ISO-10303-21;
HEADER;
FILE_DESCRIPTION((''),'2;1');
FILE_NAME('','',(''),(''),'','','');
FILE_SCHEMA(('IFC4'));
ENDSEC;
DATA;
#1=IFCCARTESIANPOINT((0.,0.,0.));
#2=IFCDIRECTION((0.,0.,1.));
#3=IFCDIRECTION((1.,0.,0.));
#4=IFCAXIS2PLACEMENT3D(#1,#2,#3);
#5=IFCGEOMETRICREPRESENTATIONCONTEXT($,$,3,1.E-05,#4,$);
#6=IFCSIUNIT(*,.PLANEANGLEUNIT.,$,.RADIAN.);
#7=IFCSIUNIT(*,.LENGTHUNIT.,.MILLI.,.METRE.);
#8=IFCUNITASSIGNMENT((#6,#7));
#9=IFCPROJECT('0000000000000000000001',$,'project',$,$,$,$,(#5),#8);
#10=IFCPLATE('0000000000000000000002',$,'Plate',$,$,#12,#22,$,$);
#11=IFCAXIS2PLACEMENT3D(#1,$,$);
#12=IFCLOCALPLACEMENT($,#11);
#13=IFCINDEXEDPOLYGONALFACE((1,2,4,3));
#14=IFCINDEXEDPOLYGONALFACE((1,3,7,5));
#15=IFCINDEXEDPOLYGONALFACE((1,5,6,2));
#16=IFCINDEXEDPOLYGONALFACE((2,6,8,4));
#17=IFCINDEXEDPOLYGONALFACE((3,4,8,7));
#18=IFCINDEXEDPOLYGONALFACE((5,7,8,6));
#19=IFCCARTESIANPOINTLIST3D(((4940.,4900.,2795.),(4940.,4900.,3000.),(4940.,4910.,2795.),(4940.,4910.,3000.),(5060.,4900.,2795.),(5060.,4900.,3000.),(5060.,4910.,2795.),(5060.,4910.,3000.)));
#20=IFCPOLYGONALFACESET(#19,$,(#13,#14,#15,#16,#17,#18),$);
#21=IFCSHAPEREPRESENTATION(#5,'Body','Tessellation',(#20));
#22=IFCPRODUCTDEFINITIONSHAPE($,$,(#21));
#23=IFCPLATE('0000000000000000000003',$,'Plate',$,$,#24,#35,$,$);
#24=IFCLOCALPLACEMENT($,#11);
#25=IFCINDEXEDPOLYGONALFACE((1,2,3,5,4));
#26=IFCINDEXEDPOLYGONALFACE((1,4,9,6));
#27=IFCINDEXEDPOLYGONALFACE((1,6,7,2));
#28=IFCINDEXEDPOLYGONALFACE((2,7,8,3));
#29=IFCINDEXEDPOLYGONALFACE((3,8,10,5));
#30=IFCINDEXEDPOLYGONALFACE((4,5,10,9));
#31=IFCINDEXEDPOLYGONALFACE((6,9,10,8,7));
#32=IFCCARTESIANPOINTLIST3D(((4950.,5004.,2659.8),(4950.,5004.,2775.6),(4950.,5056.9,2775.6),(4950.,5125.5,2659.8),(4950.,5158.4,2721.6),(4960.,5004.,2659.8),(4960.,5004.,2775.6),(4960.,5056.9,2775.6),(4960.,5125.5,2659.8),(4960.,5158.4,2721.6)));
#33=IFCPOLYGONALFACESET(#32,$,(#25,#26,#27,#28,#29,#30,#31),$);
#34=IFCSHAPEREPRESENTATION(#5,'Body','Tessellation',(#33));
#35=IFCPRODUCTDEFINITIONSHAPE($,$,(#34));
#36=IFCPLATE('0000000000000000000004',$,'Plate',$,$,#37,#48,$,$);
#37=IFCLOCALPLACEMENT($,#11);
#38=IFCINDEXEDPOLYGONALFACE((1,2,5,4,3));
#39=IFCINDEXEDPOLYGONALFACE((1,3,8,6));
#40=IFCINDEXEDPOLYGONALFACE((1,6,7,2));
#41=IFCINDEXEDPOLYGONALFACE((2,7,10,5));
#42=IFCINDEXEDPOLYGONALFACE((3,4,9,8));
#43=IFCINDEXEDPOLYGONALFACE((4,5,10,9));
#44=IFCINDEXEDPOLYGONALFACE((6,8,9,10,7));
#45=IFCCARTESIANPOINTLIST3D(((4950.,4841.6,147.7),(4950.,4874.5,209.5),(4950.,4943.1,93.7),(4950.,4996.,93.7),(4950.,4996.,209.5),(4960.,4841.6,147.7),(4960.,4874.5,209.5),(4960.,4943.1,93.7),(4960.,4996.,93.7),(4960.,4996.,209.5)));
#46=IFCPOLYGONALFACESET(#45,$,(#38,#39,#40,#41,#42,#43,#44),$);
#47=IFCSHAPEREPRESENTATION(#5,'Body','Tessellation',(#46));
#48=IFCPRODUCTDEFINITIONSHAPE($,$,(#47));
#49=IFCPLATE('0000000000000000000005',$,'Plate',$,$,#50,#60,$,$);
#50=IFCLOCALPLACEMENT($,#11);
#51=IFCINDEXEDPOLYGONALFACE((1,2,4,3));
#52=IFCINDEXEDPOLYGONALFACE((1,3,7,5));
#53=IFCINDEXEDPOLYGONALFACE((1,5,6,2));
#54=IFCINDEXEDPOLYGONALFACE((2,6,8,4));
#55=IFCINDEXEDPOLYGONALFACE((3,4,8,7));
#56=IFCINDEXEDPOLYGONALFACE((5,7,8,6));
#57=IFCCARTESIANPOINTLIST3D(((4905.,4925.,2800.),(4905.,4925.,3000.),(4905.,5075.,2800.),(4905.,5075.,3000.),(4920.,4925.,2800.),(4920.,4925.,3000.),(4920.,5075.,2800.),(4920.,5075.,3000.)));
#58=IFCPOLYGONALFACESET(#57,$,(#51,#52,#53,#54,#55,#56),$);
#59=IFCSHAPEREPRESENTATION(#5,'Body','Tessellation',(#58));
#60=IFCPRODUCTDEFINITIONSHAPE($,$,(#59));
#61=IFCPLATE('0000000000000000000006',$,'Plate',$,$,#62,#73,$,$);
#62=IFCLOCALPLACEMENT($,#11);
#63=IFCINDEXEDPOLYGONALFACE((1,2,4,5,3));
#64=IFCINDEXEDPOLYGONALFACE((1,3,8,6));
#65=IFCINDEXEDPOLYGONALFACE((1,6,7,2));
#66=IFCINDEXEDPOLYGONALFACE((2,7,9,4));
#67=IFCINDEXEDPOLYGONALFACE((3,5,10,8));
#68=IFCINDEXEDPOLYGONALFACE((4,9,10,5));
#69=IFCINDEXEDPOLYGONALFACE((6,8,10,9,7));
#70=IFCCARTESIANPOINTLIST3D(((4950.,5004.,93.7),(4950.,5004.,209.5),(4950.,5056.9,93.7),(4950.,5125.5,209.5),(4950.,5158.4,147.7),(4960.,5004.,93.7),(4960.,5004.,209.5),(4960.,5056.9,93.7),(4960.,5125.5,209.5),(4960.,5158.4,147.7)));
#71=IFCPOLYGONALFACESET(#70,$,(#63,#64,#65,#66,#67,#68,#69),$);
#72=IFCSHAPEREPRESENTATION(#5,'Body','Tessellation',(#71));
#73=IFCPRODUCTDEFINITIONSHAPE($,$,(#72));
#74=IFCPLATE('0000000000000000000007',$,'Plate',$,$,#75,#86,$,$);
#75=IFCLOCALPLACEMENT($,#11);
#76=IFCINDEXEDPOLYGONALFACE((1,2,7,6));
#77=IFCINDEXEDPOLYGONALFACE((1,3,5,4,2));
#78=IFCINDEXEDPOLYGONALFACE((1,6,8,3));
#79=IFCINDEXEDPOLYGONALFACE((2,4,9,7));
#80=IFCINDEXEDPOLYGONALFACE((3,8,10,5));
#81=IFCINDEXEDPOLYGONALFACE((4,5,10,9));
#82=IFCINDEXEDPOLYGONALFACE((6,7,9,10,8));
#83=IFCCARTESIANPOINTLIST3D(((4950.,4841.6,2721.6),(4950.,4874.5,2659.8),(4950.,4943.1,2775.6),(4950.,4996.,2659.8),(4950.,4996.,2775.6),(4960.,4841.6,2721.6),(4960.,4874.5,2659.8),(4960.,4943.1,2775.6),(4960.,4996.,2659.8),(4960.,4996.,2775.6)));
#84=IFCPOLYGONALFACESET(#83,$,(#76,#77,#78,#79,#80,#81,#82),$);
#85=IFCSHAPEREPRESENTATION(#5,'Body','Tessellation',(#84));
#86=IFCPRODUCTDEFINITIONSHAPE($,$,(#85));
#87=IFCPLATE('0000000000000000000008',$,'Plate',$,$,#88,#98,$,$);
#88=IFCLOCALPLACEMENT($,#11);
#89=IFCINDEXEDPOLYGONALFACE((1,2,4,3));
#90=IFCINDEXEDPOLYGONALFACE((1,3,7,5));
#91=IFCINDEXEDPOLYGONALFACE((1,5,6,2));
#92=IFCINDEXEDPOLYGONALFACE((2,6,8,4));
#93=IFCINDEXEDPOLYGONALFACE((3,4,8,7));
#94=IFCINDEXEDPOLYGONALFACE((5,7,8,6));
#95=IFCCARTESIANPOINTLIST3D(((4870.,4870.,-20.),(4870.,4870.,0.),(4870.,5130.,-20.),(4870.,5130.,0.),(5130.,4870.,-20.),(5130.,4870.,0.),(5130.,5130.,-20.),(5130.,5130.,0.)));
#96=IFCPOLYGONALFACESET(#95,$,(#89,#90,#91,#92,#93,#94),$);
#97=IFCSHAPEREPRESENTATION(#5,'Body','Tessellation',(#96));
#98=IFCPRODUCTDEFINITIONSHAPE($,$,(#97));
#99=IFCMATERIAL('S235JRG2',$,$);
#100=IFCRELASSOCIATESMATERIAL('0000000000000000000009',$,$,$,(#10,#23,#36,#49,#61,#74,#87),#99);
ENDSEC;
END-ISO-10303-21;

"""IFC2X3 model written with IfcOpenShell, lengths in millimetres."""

from ifc_helpers import new_model, si_unit, frame, origin_with_axes, place, context, project, polyline, outline, extrude, material, element, save


model = new_model("IFC2X3")

# Units and contexts
context_of_model = context(None, 3, precision=1e-05, world=origin_with_axes())
ifc_project = project(units=[si_unit("PLANEANGLEUNIT", "RADIAN"), si_unit("LENGTHUNIT", "METRE", prefix="MILLI")], contexts=[context_of_model])

# Shared definitions
ifc_material = material(Name="S235JRG2")

# Plates
placement_1 = place(None, origin_with_axes())
plate_1_placement = place(placement_1, frame((5060.0, 4900.0, 2795.0), z_axis=(0.0, 0.0, 1.0), x_axis=(0.0, 1.0, 0.0)))
element("IfcPlate", 1, at=plate_1_placement, material=ifc_material, Name="Plate", context=context_of_model, shape_type="SweptSolid", body=[
    extrude(outline(polyline([(0.0, 0.0), (120.0, 0.0), (120.0, 205.0), (0.0, 205.0), (0.0, 0.0)])), frame((0.0, 0.0, 0.0), z_axis=(1.0, 0.0, 0.0), x_axis=(0.0, 1.0, 0.0)), (0.0, 0.0, 1.0), 10.0),
])
placement_2 = place(None, origin_with_axes())
plate_2_placement = place(placement_2, frame((4950.0, 5056.9, 2775.6), z_axis=(0.0, 0.0, -1.0), x_axis=(1.0, 0.0, 0.0)))
element("IfcPlate", 2, at=plate_2_placement, material=ifc_material, Name="Plate", context=context_of_model, shape_type="SweptSolid", body=[
    extrude(outline(polyline([(0.0, 0.0), (52.9, 0.0), (52.9, 115.8), (-68.6, 115.8), (-101.5, 54.1), (0.0, 0.0)])), frame((0.0, 0.0, 0.0), z_axis=(1.0, 0.0, 0.0), x_axis=(0.0, 1.0, 0.0)), (0.0, 0.0, 1.0), 10.0),
])
placement_3 = place(None, origin_with_axes())
plate_3_placement = place(placement_3, frame((4950.0, 4943.1, 93.7), z_axis=(0.0, 0.0, 1.0), x_axis=(1.0, 0.0, 0.0)))
element("IfcPlate", 3, at=plate_3_placement, material=ifc_material, Name="Plate", context=context_of_model, shape_type="SweptSolid", body=[
    extrude(outline(polyline([(0.0, 0.0), (52.9, 0.0), (52.9, 115.8), (-68.6, 115.8), (-101.5, 54.1), (0.0, 0.0)])), frame((0.0, 0.0, 0.0), z_axis=(1.0, 0.0, 0.0), x_axis=(0.0, 1.0, 0.0)), (0.0, 0.0, 1.0), 10.0),
])
placement_4 = place(None, origin_with_axes())
plate_4_placement = place(placement_4, frame((4905.0, 5075.0, 2800.0), z_axis=(0.0, -1.0, 0.0), x_axis=(1.0, 0.0, 0.0)))
element("IfcPlate", 4, at=plate_4_placement, material=ifc_material, Name="Plate", context=context_of_model, shape_type="SweptSolid", body=[
    extrude(outline(polyline([(0.0, 0.0), (200.0, 0.0), (200.0, 150.0), (0.0, 150.0), (0.0, 0.0)])), frame((0.0, 0.0, 0.0), z_axis=(1.0, 0.0, 0.0), x_axis=(0.0, 1.0, 0.0)), (0.0, 0.0, 1.0), 15.0),
])
placement_5 = place(None, origin_with_axes())
plate_5_placement = place(placement_5, frame((4960.0, 5056.9, 93.7), z_axis=(0.0, 0.0, 1.0), x_axis=(-1.0, 0.0, 0.0)))
element("IfcPlate", 5, at=plate_5_placement, material=ifc_material, Name="Plate", context=context_of_model, shape_type="SweptSolid", body=[
    extrude(outline(polyline([(0.0, 0.0), (52.9, 0.0), (52.9, 115.8), (-68.6, 115.8), (-101.5, 54.1), (0.0, 0.0)])), frame((0.0, 0.0, 0.0), z_axis=(1.0, 0.0, 0.0), x_axis=(0.0, 1.0, 0.0)), (0.0, 0.0, 1.0), 10.0),
])
placement_6 = place(None, origin_with_axes())
plate_6_placement = place(placement_6, frame((4960.0, 4943.1, 2775.6), z_axis=(0.0, 0.0, -1.0), x_axis=(-1.0, 0.0, 0.0)))
element("IfcPlate", 6, at=plate_6_placement, material=ifc_material, Name="Plate", context=context_of_model, shape_type="SweptSolid", body=[
    extrude(outline(polyline([(0.0, 0.0), (52.9, 0.0), (52.9, 115.8), (-68.6, 115.8), (-101.5, 54.1), (0.0, 0.0)])), frame((0.0, 0.0, 0.0), z_axis=(1.0, 0.0, 0.0), x_axis=(0.0, 1.0, 0.0)), (0.0, 0.0, 1.0), 10.0),
])
placement_7 = place(None, origin_with_axes())
plate_7_placement = place(placement_7, frame((4870.0, 4870.0, 0.0), z_axis=(1.0, 0.0, 0.0), x_axis=(0.0, 0.0, -1.0)))
element("IfcPlate", 7, at=plate_7_placement, material=ifc_material, Name="Plate", context=context_of_model, shape_type="SweptSolid", body=[
    extrude(outline(polyline([(0.0, 0.0), (260.0, 0.0), (260.0, 260.0), (0.0, 260.0), (0.0, 0.0)])), frame((0.0, 0.0, 0.0), z_axis=(1.0, 0.0, 0.0), x_axis=(0.0, 1.0, 0.0)), (0.0, 0.0, 1.0), 20.0),
])

save(model, "model.ifc")
